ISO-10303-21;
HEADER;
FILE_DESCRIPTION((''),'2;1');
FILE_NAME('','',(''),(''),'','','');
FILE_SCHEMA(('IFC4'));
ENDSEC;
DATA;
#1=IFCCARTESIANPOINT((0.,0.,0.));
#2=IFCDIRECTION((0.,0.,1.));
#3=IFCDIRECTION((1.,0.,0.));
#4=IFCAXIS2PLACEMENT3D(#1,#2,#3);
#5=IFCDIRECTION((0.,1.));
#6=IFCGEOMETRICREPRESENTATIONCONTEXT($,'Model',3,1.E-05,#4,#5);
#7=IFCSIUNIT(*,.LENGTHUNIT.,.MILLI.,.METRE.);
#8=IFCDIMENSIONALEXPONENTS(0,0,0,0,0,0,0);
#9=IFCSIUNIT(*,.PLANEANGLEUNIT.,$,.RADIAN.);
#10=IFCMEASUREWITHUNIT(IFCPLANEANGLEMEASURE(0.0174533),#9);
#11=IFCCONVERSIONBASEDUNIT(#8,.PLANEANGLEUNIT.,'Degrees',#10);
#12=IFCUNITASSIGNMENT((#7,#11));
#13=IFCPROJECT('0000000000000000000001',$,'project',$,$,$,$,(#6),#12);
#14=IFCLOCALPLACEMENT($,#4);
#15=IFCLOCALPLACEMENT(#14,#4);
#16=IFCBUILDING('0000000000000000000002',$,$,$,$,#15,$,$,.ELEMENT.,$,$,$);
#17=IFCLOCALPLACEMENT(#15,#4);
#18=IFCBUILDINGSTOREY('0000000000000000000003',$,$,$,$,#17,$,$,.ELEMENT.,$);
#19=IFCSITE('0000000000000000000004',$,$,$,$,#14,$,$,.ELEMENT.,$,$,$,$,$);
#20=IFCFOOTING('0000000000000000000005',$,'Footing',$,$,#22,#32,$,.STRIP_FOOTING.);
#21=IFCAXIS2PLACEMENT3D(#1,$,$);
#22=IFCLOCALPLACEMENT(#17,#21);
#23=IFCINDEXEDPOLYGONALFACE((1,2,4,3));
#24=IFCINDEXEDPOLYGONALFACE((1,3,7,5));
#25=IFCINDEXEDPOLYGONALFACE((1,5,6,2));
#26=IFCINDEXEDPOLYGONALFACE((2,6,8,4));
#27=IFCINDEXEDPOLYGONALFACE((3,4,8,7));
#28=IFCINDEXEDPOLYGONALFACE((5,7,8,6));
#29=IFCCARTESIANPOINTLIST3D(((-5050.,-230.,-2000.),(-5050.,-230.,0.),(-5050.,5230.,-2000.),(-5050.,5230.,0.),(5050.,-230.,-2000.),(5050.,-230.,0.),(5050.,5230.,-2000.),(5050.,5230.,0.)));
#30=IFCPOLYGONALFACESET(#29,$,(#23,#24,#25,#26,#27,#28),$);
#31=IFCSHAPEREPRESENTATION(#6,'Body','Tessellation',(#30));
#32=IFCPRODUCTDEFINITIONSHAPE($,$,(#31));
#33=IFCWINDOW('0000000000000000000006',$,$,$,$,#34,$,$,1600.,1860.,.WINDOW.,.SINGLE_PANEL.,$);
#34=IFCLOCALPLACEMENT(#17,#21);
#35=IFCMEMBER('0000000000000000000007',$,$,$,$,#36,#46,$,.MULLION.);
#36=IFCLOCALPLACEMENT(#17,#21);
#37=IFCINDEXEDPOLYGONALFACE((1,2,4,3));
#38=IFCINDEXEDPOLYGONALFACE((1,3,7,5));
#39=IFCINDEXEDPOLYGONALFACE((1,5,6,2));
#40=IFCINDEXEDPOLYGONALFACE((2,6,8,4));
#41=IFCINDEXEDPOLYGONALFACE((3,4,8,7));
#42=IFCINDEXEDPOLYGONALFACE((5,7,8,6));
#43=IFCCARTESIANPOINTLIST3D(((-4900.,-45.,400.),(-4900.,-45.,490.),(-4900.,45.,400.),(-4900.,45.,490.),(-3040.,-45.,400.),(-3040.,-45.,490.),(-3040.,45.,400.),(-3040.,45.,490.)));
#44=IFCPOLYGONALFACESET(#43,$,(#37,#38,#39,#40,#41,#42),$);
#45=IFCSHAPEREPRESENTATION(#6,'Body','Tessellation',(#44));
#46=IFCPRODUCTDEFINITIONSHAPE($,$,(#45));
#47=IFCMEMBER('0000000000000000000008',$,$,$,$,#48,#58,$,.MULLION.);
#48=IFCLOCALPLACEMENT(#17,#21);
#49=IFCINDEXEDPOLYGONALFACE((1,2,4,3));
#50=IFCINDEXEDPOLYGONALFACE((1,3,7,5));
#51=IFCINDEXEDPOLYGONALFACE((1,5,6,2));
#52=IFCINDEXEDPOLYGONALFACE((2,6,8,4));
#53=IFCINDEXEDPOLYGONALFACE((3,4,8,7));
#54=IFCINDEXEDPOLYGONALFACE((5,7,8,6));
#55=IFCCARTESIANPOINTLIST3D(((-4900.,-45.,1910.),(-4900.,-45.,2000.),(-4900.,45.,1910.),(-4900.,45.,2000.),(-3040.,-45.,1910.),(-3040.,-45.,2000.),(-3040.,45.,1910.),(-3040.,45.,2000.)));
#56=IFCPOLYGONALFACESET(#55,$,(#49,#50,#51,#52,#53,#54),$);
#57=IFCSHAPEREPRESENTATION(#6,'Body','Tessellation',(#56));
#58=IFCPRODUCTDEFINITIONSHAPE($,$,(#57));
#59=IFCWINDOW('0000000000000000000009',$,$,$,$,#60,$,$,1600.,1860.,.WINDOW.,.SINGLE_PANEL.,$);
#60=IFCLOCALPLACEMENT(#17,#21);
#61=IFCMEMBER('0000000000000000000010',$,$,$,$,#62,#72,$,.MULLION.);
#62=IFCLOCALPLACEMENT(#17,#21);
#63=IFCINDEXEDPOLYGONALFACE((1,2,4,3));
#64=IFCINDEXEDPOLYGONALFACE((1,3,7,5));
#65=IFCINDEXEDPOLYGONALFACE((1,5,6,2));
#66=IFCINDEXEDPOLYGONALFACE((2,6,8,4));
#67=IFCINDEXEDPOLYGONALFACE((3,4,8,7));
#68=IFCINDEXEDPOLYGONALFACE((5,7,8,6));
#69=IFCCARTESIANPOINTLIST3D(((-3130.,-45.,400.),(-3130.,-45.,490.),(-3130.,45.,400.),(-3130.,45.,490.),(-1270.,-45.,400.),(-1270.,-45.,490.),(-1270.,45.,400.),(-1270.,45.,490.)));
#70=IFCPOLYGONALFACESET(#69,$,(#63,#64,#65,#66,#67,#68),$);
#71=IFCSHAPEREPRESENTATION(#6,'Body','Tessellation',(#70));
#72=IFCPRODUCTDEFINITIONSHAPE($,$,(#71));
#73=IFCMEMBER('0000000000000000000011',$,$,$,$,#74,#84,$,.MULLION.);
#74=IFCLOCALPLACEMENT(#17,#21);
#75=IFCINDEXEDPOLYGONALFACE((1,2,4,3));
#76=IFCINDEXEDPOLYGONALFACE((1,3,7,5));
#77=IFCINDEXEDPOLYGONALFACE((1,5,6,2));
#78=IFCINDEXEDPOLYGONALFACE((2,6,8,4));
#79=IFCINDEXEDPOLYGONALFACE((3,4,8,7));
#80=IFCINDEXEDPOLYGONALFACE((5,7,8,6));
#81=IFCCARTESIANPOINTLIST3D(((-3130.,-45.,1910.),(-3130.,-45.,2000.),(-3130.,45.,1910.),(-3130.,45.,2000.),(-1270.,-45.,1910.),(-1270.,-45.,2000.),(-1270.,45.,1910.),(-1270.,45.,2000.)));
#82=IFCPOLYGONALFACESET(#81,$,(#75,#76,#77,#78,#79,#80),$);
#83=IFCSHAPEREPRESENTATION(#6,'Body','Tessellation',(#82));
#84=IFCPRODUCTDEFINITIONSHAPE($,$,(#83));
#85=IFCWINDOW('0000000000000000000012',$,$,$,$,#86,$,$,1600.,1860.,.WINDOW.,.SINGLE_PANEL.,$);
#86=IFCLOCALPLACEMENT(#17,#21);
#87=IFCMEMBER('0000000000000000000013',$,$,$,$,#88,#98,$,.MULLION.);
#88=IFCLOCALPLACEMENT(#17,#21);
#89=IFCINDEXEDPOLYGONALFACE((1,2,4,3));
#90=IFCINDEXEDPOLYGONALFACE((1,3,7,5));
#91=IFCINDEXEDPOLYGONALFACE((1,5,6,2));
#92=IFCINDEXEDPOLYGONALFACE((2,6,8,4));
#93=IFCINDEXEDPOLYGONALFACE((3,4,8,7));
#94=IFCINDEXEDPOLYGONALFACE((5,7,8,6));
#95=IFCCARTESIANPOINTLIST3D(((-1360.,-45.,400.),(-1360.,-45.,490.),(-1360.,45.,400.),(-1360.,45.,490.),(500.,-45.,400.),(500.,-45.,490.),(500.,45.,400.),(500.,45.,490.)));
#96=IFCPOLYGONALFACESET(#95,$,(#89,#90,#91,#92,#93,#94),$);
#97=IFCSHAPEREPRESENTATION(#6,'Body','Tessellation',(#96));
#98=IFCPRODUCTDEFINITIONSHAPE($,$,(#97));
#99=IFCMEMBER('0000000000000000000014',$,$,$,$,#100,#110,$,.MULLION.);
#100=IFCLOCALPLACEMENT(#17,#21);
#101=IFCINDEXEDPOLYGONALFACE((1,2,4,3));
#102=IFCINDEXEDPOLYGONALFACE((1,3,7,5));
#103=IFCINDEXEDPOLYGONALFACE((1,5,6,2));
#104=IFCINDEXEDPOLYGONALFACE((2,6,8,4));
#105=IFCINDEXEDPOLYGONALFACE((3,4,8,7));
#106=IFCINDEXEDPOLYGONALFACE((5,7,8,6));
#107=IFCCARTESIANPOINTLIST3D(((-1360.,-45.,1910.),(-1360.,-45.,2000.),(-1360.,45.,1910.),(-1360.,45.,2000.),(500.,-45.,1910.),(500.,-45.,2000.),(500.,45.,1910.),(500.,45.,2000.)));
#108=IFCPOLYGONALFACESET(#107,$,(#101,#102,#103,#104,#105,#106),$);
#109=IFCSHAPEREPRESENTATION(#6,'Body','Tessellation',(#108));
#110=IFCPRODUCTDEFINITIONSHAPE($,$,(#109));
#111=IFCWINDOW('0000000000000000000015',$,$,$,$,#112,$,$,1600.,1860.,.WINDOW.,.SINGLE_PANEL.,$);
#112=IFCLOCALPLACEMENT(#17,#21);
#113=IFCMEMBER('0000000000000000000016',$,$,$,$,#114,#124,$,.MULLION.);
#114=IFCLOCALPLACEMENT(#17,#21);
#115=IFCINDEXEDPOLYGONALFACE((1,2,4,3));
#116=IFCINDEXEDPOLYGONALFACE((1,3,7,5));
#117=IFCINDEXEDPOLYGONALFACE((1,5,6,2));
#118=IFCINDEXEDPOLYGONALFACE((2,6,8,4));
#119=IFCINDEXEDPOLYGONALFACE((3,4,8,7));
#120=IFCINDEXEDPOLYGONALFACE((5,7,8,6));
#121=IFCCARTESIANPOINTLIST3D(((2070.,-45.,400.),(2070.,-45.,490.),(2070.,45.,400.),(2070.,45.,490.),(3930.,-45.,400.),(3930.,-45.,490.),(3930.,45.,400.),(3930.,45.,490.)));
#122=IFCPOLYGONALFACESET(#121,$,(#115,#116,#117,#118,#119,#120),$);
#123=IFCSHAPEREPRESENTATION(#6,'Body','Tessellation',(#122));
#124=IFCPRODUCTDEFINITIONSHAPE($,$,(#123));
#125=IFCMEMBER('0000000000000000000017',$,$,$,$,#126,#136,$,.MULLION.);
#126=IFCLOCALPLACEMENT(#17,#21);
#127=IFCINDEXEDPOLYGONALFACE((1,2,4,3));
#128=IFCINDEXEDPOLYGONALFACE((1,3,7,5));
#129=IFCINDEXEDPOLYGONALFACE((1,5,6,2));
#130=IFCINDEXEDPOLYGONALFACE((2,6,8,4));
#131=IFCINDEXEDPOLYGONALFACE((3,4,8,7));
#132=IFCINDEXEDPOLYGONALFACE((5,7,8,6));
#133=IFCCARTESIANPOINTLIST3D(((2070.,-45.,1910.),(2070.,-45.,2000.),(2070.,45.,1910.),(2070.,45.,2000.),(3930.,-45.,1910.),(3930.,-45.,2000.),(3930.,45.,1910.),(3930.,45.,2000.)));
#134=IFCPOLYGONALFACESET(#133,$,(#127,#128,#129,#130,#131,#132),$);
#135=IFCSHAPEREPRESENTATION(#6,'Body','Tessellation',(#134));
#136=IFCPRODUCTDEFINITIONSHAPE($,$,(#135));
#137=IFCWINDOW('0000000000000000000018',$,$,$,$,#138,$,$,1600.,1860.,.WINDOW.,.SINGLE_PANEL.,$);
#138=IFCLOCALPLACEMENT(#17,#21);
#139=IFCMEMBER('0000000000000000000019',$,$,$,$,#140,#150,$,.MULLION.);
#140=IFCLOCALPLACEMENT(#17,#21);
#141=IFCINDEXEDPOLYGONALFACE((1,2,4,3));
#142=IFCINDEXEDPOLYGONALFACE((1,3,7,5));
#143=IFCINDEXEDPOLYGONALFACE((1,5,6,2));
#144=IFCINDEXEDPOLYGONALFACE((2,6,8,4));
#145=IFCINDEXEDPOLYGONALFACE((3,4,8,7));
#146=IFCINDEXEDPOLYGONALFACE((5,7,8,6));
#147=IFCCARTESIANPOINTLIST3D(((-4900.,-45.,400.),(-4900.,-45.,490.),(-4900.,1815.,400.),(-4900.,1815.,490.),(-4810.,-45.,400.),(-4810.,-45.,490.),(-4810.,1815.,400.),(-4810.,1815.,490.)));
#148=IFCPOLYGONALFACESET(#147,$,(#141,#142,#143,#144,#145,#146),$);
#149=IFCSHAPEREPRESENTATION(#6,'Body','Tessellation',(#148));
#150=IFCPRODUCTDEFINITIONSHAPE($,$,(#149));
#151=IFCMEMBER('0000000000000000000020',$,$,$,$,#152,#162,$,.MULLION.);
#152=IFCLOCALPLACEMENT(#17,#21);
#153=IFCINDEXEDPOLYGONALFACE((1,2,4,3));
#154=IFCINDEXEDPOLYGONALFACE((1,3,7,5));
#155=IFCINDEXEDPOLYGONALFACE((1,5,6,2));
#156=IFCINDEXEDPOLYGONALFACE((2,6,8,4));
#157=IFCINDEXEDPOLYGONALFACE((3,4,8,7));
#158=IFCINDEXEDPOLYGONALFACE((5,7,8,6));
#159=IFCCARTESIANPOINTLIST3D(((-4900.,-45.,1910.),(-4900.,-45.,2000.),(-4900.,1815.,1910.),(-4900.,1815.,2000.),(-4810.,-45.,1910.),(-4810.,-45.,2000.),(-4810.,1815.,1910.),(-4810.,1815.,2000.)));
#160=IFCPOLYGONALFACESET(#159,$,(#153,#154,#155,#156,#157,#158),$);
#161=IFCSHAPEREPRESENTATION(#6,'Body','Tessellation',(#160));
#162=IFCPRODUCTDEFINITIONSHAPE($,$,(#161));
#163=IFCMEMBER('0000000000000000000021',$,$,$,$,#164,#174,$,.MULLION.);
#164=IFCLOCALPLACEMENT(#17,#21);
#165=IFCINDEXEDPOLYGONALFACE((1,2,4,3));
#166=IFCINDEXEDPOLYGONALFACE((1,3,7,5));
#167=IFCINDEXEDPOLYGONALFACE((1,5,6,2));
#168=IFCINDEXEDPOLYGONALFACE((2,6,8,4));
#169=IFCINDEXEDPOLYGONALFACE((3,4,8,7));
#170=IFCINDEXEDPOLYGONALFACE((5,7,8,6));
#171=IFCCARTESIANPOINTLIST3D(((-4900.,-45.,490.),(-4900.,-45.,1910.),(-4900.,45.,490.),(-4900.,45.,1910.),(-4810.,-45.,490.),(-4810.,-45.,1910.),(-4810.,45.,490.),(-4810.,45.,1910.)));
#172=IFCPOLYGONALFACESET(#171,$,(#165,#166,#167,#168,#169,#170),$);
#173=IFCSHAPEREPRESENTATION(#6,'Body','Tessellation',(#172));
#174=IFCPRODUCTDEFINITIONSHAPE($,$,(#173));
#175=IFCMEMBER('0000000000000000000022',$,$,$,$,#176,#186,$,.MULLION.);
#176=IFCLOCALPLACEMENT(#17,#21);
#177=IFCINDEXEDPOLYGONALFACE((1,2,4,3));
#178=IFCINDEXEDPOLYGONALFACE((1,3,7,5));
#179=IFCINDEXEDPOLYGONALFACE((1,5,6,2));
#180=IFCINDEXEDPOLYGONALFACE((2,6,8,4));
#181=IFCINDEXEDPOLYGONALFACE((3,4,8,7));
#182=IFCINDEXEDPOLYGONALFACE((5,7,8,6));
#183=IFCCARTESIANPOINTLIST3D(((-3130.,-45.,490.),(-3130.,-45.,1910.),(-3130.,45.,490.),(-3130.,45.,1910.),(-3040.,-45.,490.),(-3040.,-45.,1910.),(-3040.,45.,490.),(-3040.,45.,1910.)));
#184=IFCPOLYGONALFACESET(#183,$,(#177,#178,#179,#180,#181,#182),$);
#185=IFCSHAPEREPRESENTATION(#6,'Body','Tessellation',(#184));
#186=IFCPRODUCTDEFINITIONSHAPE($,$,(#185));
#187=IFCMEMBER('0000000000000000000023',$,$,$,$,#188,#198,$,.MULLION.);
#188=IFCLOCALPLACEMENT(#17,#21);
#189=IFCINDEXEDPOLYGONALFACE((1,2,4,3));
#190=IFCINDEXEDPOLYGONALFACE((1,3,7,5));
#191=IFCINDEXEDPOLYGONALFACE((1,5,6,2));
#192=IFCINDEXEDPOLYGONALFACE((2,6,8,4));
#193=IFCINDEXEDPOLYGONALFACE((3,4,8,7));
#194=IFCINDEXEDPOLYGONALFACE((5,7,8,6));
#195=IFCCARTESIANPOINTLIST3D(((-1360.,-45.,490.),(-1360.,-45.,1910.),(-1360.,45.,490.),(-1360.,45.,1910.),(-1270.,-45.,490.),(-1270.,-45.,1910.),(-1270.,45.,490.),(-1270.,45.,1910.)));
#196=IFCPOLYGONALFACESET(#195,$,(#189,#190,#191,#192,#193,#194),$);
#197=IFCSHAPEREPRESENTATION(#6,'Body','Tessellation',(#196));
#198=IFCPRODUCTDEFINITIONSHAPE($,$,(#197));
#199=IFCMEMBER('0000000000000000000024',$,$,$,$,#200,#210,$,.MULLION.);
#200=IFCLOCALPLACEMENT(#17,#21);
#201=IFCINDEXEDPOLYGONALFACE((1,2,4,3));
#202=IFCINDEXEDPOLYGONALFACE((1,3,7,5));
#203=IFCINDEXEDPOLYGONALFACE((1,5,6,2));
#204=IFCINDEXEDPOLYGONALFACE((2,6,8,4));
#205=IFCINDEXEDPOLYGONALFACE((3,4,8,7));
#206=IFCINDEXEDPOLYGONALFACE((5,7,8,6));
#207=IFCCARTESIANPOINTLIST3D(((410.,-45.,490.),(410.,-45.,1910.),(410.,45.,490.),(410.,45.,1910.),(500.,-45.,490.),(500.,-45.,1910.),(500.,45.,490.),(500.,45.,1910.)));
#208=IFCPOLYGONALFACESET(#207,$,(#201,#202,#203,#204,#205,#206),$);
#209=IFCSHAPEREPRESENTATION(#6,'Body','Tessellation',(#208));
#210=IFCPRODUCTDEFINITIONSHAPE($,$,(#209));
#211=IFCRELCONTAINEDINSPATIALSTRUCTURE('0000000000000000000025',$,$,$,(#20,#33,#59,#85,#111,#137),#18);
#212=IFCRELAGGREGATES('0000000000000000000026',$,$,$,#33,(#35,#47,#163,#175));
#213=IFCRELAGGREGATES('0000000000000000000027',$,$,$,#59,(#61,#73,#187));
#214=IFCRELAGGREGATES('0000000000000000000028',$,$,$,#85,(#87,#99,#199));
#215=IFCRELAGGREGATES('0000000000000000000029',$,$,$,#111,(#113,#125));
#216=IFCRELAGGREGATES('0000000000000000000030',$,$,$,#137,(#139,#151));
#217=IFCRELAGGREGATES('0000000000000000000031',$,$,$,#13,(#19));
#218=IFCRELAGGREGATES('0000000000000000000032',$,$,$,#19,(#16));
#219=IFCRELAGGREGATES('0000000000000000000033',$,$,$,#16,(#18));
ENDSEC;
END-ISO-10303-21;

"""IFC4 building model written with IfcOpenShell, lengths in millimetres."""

from ifc_helpers import new_model, entity, si_unit, converted_unit, direction, frame, origin_with_axes, place, context, project, spatial, polyline, outline, extrude, source, transform, mapped, element, aggregate, save


model = new_model("IFC4")

# Units and contexts
model_context = context("Model", 3, precision=1e-05, world=origin_with_axes(), true_north=direction((0.0, 1.0)))
ifc_project = project(units=[si_unit("LENGTHUNIT", "METRE", prefix="MILLI"), converted_unit("PLANEANGLEUNIT", "Degrees", entity("IfcPlaneAngleMeasure", 0.0174533), si_unit("PLANEANGLEUNIT", "RADIAN"), dimensions=[0, 0, 0, 0, 0, 0, 0])], contexts=[model_context])

# Site, building, storey
site_placement = place(None, origin_with_axes())
site = spatial("IfcSite", under=ifc_project, at=site_placement, CompositionType="ELEMENT")
building_placement = place(site_placement, origin_with_axes())
building = spatial("IfcBuilding", under=site, at=building_placement, CompositionType="ELEMENT")
storey_placement = place(building_placement, origin_with_axes())
storey = spatial("IfcBuildingStorey", under=building, at=storey_placement, CompositionType="ELEMENT")

# Footing
footing_placement = place(storey_placement, frame((0.0, 2500.0, -2000.0), z_axis=(0.0, 0.0, 1.0), x_axis=(1.0, 0.0, 0.0)))
element("IfcFooting", 1, at=footing_placement, inside=storey, Name="Footing", PredefinedType="STRIP_FOOTING", context=model_context, shape_type="SweptSolid", body=[
    extrude(outline(polyline([(-5050.0, -2730.0), (5050.0, -2730.0), (5050.0, 2730.0), (-5050.0, 2730.0), (-5050.0, -2730.0), (-5050.0, -2730.0)])), origin_with_axes(), (0.0, 0.0, 1.0), 2000.0),
])

# Windows, members
window_1_placement = place(storey_placement, frame((-4900.0, -45.0, 400.0), z_axis=(0.0, 0.0, 1.0), x_axis=(1.0, 0.0, 0.0)))
window_1 = element("IfcWindow", 2, at=window_1_placement, inside=storey, OverallHeight=1600.0, OverallWidth=1860.0, PartitioningType="SINGLE_PANEL", PredefinedType="WINDOW")
shared_shape_1 = source(origin_with_axes(), model_context, "Body", "SweptSolid", [
    extrude(outline(polyline([(-930.0, -45.0), (930.0, -45.0), (930.0, 45.0), (-930.0, 45.0), (-930.0, -45.0), (-930.0, -45.0)])), origin_with_axes(), (0.0, 0.0, 1.0), 90.0),
])
member_1_placement = place(window_1_placement, frame((930.0, 45.0, 0.0), z_axis=(0.0, 0.0, 1.0), x_axis=(1.0, 0.0, 0.0)))
member_1 = element("IfcMember", 3, at=member_1_placement, PredefinedType="MULLION", context=model_context, shape_type="MappedRepresentation", body=[
    mapped(shared_shape_1, transform((0.0, 0.0, 0.0))),
])
member_2_placement = place(window_1_placement, frame((930.0, 45.0, 1510.0), z_axis=(0.0, 0.0, 1.0), x_axis=(1.0, 0.0, 0.0)))
member_2 = element("IfcMember", 4, at=member_2_placement, PredefinedType="MULLION", context=model_context, shape_type="MappedRepresentation", body=[
    mapped(shared_shape_1, transform((0.0, 0.0, 0.0))),
])
window_2_placement = place(storey_placement, frame((-3130.0, -45.0, 400.0), z_axis=(0.0, 0.0, 1.0), x_axis=(1.0, 0.0, 0.0)))
window_2 = element("IfcWindow", 5, at=window_2_placement, inside=storey, OverallHeight=1600.0, OverallWidth=1860.0, PartitioningType="SINGLE_PANEL", PredefinedType="WINDOW")
member_3_placement = place(window_2_placement, frame((930.0, 45.0, 0.0), z_axis=(0.0, 0.0, 1.0), x_axis=(1.0, 0.0, 0.0)))
member_3 = element("IfcMember", 6, at=member_3_placement, PredefinedType="MULLION", context=model_context, shape_type="MappedRepresentation", body=[
    mapped(shared_shape_1, transform((0.0, 0.0, 0.0))),
])
member_4_placement = place(window_2_placement, frame((930.0, 45.0, 1510.0), z_axis=(0.0, 0.0, 1.0), x_axis=(1.0, 0.0, 0.0)))
member_4 = element("IfcMember", 7, at=member_4_placement, PredefinedType="MULLION", context=model_context, shape_type="MappedRepresentation", body=[
    mapped(shared_shape_1, transform((0.0, 0.0, 0.0))),
])
window_3_placement = place(storey_placement, frame((-1360.0, -45.0, 400.0), z_axis=(0.0, 0.0, 1.0), x_axis=(1.0, 0.0, 0.0)))
window_3 = element("IfcWindow", 8, at=window_3_placement, inside=storey, OverallHeight=1600.0, OverallWidth=1860.0, PartitioningType="SINGLE_PANEL", PredefinedType="WINDOW")
member_5_placement = place(window_3_placement, frame((930.0, 45.0, 0.0), z_axis=(0.0, 0.0, 1.0), x_axis=(1.0, 0.0, 0.0)))
member_5 = element("IfcMember", 9, at=member_5_placement, PredefinedType="MULLION", context=model_context, shape_type="MappedRepresentation", body=[
    mapped(shared_shape_1, transform((0.0, 0.0, 0.0))),
])
member_6_placement = place(window_3_placement, frame((930.0, 45.0, 1510.0), z_axis=(0.0, 0.0, 1.0), x_axis=(1.0, 0.0, 0.0)))
member_6 = element("IfcMember", 10, at=member_6_placement, PredefinedType="MULLION", context=model_context, shape_type="MappedRepresentation", body=[
    mapped(shared_shape_1, transform((0.0, 0.0, 0.0))),
])
window_4_placement = place(storey_placement, frame((2070.0, -45.0, 400.0), z_axis=(0.0, 0.0, 1.0), x_axis=(1.0, 0.0, 0.0)))
window_4 = element("IfcWindow", 11, at=window_4_placement, inside=storey, OverallHeight=1600.0, OverallWidth=1860.0, PartitioningType="SINGLE_PANEL", PredefinedType="WINDOW")
member_7_placement = place(window_4_placement, frame((930.0, 45.0, 0.0), z_axis=(0.0, 0.0, 1.0), x_axis=(1.0, 0.0, 0.0)))
member_7 = element("IfcMember", 12, at=member_7_placement, PredefinedType="MULLION", context=model_context, shape_type="MappedRepresentation", body=[
    mapped(shared_shape_1, transform((0.0, 0.0, 0.0))),
])
member_8_placement = place(window_4_placement, frame((930.0, 45.0, 1510.0), z_axis=(0.0, 0.0, 1.0), x_axis=(1.0, 0.0, 0.0)))
member_8 = element("IfcMember", 13, at=member_8_placement, PredefinedType="MULLION", context=model_context, shape_type="MappedRepresentation", body=[
    mapped(shared_shape_1, transform((0.0, 0.0, 0.0))),
])
window_5_placement = place(storey_placement, frame((-4810.0, -45.0, 400.0), z_axis=(0.0, 0.0, 1.0), x_axis=(0.0, 1.0, 0.0)))
window_5 = element("IfcWindow", 14, at=window_5_placement, inside=storey, OverallHeight=1600.0, OverallWidth=1860.0, PartitioningType="SINGLE_PANEL", PredefinedType="WINDOW")
member_9_placement = place(window_5_placement, frame((930.0, 45.0, 0.0), z_axis=(0.0, 0.0, 1.0), x_axis=(1.0, 0.0, 0.0)))
member_9 = element("IfcMember", 15, at=member_9_placement, PredefinedType="MULLION", context=model_context, shape_type="MappedRepresentation", body=[
    mapped(shared_shape_1, transform((0.0, 0.0, 0.0))),
])
member_10_placement = place(window_5_placement, frame((930.0, 45.0, 1510.0), z_axis=(0.0, 0.0, 1.0), x_axis=(1.0, 0.0, 0.0)))
member_10 = element("IfcMember", 16, at=member_10_placement, PredefinedType="MULLION", context=model_context, shape_type="MappedRepresentation", body=[
    mapped(shared_shape_1, transform((0.0, 0.0, 0.0))),
])

# Members
shared_shape_2 = source(origin_with_axes(), model_context, "Body", "SweptSolid", [
    extrude(outline(polyline([(-45.0, -45.0), (45.0, -45.0), (45.0, 45.0), (-45.0, 45.0), (-45.0, -45.0), (-45.0, -45.0)])), origin_with_axes(), (0.0, 0.0, 1.0), 1420.0),
])
member_11_placement = place(window_1_placement, frame((45.0, 45.0, 90.0), z_axis=(0.0, 0.0, 1.0), x_axis=(1.0, 0.0, 0.0)))
member_11 = element("IfcMember", 17, at=member_11_placement, PredefinedType="MULLION", context=model_context, shape_type="MappedRepresentation", body=[
    mapped(shared_shape_2, transform((0.0, 0.0, 0.0))),
])
member_12_placement = place(window_1_placement, frame((1815.0, 45.0, 90.0), z_axis=(0.0, 0.0, 1.0), x_axis=(1.0, 0.0, 0.0)))
member_12 = element("IfcMember", 18, at=member_12_placement, PredefinedType="MULLION", context=model_context, shape_type="MappedRepresentation", body=[
    mapped(shared_shape_2, transform((0.0, 0.0, 0.0))),
])
member_13_placement = place(window_2_placement, frame((1815.0, 45.0, 90.0), z_axis=(0.0, 0.0, 1.0), x_axis=(1.0, 0.0, 0.0)))
member_13 = element("IfcMember", 19, at=member_13_placement, PredefinedType="MULLION", context=model_context, shape_type="MappedRepresentation", body=[
    mapped(shared_shape_2, transform((0.0, 0.0, 0.0))),
])
member_14_placement = place(window_3_placement, frame((1815.0, 45.0, 90.0), z_axis=(0.0, 0.0, 1.0), x_axis=(1.0, 0.0, 0.0)))
member_14 = element("IfcMember", 20, at=member_14_placement, PredefinedType="MULLION", context=model_context, shape_type="MappedRepresentation", body=[
    mapped(shared_shape_2, transform((0.0, 0.0, 0.0))),
])

aggregate(window_1, [member_1, member_2, member_11, member_12])
aggregate(window_2, [member_3, member_4, member_13])
aggregate(window_3, [member_5, member_6, member_14])
aggregate(window_4, [member_7, member_8])
aggregate(window_5, [member_9, member_10])

save(model, "model.ifc")
